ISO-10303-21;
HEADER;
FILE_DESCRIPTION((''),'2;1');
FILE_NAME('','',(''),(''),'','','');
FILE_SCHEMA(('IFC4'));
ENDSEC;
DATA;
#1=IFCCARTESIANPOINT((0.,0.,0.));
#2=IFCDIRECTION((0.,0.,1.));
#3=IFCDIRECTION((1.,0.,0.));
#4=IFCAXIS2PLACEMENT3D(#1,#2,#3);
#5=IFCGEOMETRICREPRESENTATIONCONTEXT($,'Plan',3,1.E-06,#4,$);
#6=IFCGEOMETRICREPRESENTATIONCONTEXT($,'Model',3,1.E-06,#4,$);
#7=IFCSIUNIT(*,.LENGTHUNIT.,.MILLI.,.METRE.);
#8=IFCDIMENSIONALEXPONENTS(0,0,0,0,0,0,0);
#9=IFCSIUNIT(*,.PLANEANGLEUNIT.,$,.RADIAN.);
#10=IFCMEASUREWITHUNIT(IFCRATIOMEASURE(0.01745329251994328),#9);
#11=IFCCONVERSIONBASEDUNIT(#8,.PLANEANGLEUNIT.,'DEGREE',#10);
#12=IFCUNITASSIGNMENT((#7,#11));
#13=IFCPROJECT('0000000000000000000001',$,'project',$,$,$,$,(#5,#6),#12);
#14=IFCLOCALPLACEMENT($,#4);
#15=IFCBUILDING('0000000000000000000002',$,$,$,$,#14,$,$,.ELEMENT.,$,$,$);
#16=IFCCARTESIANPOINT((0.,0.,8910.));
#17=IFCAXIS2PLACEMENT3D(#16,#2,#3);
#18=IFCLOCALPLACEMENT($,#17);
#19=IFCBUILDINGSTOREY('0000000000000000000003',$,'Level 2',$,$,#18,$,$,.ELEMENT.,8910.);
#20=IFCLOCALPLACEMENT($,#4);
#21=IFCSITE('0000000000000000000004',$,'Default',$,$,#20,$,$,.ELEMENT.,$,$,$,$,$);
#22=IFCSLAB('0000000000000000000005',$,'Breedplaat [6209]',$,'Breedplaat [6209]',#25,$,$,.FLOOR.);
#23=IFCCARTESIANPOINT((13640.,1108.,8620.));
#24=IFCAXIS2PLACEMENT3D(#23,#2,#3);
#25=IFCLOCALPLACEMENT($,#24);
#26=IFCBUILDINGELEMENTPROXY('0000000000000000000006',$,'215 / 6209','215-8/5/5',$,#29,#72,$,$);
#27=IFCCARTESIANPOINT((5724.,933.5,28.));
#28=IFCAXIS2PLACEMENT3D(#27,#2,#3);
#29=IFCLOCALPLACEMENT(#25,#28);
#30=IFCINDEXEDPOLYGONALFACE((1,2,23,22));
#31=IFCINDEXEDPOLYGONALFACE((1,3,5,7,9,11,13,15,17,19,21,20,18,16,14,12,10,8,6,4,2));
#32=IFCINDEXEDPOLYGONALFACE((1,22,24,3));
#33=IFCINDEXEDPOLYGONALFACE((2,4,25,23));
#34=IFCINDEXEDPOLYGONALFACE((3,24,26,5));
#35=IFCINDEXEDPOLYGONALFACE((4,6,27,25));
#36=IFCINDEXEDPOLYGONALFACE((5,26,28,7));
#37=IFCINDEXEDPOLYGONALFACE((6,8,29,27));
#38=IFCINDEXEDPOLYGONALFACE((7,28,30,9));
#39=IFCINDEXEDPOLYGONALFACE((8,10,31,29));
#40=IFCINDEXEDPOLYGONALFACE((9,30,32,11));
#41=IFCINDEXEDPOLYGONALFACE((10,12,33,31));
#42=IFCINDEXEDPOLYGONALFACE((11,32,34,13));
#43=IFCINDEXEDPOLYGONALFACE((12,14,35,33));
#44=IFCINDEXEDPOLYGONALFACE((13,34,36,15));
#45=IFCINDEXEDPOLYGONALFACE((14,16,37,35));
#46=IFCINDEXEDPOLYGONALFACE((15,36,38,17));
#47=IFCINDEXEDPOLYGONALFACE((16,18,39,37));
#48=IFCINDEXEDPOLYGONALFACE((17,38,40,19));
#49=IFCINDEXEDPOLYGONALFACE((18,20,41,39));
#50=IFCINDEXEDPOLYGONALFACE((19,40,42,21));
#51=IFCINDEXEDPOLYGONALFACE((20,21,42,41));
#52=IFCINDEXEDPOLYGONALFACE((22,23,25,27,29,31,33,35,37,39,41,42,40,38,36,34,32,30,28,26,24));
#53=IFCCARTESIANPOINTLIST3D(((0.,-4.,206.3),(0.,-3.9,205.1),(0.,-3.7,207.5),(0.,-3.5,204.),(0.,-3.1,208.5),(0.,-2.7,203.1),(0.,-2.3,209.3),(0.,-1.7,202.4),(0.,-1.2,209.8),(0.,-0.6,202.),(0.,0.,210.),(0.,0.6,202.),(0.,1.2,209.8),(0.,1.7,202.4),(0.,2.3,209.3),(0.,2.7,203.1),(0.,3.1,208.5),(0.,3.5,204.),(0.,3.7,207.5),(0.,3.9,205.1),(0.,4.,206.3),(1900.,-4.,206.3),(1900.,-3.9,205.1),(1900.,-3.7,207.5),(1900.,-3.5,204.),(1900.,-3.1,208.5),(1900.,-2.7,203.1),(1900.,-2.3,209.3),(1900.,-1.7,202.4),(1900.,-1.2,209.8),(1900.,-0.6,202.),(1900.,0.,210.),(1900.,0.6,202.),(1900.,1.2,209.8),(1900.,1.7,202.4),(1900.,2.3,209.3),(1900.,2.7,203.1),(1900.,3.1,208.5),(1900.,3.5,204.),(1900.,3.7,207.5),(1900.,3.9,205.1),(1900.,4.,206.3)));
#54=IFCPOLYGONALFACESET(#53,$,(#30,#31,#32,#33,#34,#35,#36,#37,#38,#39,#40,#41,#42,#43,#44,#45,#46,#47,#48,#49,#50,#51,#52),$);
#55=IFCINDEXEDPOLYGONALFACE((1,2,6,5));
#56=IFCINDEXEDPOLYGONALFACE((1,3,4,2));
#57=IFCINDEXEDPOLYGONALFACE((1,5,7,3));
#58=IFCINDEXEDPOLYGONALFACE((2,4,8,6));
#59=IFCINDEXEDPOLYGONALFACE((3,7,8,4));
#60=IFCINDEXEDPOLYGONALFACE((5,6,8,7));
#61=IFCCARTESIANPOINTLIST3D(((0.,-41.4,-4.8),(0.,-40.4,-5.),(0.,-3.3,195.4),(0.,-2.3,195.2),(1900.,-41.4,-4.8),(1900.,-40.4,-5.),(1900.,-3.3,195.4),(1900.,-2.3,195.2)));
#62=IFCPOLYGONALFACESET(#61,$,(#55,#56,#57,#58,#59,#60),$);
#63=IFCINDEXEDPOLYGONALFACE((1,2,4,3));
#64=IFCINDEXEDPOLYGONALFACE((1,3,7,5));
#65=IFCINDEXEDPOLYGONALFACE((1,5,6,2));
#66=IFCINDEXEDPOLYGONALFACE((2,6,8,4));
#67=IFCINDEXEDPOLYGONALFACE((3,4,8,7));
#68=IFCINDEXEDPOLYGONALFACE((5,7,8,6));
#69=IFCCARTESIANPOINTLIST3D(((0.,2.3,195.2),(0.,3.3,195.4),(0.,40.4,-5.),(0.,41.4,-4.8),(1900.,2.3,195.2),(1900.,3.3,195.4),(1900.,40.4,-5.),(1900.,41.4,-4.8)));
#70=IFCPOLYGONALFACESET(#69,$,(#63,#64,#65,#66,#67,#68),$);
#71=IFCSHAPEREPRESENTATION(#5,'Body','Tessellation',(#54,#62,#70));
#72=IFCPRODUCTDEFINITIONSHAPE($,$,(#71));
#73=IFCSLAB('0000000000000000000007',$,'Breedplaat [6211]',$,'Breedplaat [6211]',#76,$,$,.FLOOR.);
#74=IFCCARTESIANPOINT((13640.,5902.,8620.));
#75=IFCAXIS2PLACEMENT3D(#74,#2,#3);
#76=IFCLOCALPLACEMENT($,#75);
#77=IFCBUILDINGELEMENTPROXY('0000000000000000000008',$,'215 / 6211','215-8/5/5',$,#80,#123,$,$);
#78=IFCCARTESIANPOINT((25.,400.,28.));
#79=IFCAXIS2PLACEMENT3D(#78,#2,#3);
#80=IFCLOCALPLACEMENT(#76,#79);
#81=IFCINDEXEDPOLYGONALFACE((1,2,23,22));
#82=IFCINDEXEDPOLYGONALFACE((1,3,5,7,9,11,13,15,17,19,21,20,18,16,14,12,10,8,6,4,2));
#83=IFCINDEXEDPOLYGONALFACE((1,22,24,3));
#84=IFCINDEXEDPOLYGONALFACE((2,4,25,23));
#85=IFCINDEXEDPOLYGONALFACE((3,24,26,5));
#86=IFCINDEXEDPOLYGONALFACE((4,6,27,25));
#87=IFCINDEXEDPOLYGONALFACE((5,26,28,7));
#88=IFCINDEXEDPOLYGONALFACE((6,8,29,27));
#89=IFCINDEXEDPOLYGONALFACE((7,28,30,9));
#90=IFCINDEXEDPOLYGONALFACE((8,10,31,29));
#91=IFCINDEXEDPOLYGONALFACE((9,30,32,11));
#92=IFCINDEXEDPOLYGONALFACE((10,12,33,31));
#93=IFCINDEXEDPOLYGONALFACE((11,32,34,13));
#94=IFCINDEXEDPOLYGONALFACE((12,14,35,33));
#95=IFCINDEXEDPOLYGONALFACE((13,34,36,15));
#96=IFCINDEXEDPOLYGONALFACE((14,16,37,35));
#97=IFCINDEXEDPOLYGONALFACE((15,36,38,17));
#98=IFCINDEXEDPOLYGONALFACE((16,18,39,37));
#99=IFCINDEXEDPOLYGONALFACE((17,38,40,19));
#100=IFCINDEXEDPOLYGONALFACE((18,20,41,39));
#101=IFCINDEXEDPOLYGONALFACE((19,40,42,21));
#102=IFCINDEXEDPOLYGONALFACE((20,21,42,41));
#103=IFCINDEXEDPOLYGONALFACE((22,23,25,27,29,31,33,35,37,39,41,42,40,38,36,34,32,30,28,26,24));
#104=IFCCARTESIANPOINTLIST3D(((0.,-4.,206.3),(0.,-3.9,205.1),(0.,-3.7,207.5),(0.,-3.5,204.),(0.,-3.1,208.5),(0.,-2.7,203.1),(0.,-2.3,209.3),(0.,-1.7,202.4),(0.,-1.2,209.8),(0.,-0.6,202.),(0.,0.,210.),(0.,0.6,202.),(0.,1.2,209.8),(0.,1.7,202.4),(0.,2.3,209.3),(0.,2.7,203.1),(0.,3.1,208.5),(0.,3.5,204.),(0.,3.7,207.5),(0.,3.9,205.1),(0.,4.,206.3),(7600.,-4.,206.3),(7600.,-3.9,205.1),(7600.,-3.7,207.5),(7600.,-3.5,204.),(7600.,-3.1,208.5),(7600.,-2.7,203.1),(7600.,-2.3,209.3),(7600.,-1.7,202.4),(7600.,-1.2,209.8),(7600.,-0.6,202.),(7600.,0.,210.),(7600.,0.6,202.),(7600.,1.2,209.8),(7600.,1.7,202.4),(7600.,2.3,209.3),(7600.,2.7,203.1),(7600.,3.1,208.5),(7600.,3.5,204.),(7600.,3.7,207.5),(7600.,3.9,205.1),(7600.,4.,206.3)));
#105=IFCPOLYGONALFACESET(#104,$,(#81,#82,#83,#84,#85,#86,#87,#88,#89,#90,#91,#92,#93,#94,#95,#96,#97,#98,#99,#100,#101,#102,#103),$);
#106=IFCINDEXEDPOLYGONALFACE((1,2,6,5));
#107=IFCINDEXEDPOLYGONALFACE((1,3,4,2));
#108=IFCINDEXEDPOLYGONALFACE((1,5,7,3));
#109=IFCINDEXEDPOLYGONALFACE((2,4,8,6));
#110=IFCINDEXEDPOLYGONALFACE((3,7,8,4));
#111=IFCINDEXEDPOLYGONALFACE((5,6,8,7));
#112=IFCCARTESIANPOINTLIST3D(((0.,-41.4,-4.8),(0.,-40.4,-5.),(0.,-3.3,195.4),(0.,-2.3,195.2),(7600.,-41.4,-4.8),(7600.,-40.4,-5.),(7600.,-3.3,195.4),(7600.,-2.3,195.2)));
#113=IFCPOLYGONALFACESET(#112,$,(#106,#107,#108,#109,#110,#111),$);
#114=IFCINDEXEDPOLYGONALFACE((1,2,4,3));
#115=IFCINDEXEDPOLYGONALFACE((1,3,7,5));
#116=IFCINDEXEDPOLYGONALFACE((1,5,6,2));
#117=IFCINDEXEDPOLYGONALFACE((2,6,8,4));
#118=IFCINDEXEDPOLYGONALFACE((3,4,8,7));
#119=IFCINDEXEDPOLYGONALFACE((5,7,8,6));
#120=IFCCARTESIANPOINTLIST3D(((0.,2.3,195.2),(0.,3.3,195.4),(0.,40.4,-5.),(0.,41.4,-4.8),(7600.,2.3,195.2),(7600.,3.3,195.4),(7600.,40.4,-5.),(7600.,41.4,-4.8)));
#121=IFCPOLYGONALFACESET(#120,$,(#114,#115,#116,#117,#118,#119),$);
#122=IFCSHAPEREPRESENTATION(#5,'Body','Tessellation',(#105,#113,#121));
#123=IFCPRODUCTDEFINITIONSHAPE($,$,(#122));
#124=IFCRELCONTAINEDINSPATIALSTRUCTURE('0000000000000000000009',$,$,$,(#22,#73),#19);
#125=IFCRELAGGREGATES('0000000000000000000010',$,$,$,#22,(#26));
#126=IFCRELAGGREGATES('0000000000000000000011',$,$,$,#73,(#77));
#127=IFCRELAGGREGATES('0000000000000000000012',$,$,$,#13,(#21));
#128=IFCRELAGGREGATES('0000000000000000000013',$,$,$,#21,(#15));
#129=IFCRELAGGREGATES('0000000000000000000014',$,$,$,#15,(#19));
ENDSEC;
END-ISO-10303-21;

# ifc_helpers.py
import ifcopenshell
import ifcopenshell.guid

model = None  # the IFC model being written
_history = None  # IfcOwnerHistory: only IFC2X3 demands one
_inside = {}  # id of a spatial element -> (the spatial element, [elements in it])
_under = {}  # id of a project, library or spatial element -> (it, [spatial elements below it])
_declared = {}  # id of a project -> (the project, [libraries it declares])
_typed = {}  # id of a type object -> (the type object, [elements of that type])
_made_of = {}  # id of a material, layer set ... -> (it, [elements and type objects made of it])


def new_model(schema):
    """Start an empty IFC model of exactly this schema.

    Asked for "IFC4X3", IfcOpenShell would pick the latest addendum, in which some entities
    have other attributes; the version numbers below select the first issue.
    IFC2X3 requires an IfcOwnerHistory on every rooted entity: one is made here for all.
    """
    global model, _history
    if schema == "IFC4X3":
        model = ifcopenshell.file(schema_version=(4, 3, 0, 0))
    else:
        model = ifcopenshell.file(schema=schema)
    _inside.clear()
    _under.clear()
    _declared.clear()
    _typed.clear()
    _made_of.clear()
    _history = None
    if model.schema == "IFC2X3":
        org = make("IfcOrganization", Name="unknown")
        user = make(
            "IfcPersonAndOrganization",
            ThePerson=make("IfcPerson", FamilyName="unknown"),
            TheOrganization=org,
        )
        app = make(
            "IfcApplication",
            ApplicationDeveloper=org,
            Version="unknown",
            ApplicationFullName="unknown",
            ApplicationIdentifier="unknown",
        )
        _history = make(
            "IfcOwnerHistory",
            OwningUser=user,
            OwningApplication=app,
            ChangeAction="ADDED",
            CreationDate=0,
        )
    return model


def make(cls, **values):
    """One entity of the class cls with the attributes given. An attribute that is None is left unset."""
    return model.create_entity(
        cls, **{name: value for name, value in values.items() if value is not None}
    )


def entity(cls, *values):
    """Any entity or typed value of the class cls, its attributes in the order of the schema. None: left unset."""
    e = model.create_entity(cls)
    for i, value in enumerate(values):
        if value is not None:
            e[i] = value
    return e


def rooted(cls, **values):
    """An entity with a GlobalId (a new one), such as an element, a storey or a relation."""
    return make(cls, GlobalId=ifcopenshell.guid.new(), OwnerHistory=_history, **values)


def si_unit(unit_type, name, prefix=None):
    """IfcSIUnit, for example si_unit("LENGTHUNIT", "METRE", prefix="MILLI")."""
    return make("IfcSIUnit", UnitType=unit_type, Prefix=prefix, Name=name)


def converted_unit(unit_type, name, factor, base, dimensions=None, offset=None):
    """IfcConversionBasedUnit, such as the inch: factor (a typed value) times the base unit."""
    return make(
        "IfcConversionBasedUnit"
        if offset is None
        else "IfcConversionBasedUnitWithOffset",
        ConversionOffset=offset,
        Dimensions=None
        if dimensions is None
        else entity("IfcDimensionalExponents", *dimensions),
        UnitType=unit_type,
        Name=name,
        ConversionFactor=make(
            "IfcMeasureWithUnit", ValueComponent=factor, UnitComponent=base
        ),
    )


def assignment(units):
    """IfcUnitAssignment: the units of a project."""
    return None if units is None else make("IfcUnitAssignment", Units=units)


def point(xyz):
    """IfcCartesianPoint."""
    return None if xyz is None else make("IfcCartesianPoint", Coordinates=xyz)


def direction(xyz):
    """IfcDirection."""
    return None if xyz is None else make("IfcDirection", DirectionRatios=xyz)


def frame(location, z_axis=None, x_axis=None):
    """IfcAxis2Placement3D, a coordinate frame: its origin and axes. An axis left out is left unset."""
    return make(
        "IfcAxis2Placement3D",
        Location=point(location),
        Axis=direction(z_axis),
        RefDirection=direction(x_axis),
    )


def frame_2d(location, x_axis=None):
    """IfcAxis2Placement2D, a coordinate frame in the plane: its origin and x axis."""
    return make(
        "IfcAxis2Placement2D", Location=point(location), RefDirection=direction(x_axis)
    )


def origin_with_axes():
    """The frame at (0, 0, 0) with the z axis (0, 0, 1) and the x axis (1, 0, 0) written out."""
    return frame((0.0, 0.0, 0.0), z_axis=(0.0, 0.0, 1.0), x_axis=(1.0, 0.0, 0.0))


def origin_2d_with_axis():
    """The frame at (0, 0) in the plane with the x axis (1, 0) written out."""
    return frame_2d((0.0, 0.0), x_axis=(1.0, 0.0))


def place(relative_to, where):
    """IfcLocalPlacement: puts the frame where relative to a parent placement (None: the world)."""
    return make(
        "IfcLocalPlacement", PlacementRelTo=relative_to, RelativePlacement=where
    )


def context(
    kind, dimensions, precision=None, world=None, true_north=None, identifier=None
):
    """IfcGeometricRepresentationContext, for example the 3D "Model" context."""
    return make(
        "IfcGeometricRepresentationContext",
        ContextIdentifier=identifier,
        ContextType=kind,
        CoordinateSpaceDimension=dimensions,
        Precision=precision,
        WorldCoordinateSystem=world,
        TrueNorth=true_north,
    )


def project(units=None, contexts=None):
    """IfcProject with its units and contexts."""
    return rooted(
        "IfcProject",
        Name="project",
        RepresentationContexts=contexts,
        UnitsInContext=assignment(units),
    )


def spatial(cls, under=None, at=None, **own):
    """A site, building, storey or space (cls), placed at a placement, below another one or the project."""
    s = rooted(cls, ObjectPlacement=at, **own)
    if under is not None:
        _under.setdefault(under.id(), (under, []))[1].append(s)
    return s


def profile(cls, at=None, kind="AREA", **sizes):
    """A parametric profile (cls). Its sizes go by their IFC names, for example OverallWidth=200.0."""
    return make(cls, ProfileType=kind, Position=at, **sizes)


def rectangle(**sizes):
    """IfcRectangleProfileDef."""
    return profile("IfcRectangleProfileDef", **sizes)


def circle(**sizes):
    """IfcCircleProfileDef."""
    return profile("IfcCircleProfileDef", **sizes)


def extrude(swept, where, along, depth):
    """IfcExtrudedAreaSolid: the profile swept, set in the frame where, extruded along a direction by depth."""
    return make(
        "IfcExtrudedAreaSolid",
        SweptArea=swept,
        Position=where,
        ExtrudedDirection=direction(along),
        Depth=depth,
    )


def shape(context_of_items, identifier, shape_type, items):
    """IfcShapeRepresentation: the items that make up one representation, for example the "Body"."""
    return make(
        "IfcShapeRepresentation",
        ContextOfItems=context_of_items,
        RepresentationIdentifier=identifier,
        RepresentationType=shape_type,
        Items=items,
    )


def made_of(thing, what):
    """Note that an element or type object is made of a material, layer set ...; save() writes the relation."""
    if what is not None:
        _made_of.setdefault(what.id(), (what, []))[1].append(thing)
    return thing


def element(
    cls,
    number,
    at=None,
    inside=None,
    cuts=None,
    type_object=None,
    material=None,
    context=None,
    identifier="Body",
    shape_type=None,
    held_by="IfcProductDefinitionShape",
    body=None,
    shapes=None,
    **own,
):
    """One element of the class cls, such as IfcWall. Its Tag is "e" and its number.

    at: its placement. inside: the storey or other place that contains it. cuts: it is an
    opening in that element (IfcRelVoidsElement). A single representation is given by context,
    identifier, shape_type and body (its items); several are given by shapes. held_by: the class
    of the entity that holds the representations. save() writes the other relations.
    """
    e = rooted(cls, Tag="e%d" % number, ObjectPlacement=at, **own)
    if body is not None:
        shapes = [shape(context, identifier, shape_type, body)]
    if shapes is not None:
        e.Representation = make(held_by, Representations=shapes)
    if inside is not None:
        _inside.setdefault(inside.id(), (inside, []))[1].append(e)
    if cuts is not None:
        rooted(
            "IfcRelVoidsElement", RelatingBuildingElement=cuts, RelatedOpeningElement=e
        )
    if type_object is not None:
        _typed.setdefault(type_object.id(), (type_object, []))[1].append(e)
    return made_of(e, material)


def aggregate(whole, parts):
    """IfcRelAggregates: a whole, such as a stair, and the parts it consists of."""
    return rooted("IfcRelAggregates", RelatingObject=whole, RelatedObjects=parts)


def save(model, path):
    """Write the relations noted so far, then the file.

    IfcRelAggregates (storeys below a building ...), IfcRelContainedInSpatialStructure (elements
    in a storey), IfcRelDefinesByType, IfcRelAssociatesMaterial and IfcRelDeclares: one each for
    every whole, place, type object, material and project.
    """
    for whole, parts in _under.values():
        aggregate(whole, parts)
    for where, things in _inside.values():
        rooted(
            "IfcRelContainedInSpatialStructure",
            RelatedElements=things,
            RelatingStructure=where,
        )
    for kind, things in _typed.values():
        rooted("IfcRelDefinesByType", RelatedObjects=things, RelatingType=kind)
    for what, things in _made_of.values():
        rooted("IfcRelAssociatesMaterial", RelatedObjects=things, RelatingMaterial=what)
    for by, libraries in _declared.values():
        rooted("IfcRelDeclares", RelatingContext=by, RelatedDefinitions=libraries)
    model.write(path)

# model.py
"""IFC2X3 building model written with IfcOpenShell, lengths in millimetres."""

from ifc_helpers import new_model, entity, si_unit, converted_unit, frame, origin_with_axes, origin_2d_with_axis, place, context, project, spatial, rectangle, circle, extrude, element, aggregate, save


model = new_model("IFC2X3")

# Units and contexts
plan_context = context("Plan", 3, precision=1e-06, world=origin_with_axes())
model_context = context("Model", 3, precision=1e-06, world=origin_with_axes())
ifc_project = project(units=[si_unit("LENGTHUNIT", "METRE", prefix="MILLI"), converted_unit("PLANEANGLEUNIT", "DEGREE", entity("IfcRatioMeasure", 0.01745329251994328), si_unit("PLANEANGLEUNIT", "RADIAN"), dimensions=[0, 0, 0, 0, 0, 0, 0])], contexts=[plan_context, model_context])

# Site, building, storey
site_placement = place(None, origin_with_axes())
site = spatial("IfcSite", under=ifc_project, at=site_placement, Name="Default", CompositionType="ELEMENT")
building_placement = place(None, origin_with_axes())
building = spatial("IfcBuilding", under=site, at=building_placement, CompositionType="ELEMENT")
storey_placement = place(None, frame((0.0, 0.0, 8910.0), z_axis=(0.0, 0.0, 1.0), x_axis=(1.0, 0.0, 0.0)))
storey = spatial("IfcBuildingStorey", under=building, at=storey_placement, Name="Level 2", CompositionType="ELEMENT", Elevation=8910.0)

# Slabs, building element proxies
slab_1_placement = place(None, frame((13640.0, 1108.0, 8620.0), z_axis=(0.0, 0.0, 1.0), x_axis=(1.0, 0.0, 0.0)))
slab_1 = element("IfcSlab", 1, at=slab_1_placement, inside=storey, Name="Breedplaat [6209]", ObjectType="Breedplaat [6209]", PredefinedType="FLOOR")
proxy_1_placement = place(slab_1_placement, frame((5724.0, 933.5, 28.0), z_axis=(0.0, 0.0, 1.0), x_axis=(1.0, 0.0, 0.0)))
proxy_1 = element("IfcBuildingElementProxy", 2, at=proxy_1_placement, Name="215 / 6209", Description="215-8/5/5", context=plan_context, shape_type="SweptSolid", body=[
    extrude(circle(Radius=4.0, at=origin_2d_with_axis()), frame((0.0, 0.0, 206.0), z_axis=(1.0, 0.0, 0.0), x_axis=(0.0, 0.0, 1.0)), (0.0, 0.0, 1.0), 1900.0),
    extrude(rectangle(XDim=203.8, YDim=1.0, at=origin_2d_with_axis()), frame((0.0, -21.9, 95.2), z_axis=(1.0, 0.0, 0.0), x_axis=(0.0, 0.187112, 0.982339)), (0.0, 0.0, 1.0), 1900.0),
    extrude(rectangle(XDim=203.8, YDim=1.0, at=origin_2d_with_axis()), frame((0.0, 21.9, 95.2), z_axis=(1.0, 0.0, 0.0), x_axis=(0.0, -0.187112, 0.982339)), (0.0, 0.0, 1.0), 1900.0),
])
aggregate(slab_1, [proxy_1])
slab_2_placement = place(None, frame((13640.0, 5902.0, 8620.0), z_axis=(0.0, 0.0, 1.0), x_axis=(1.0, 0.0, 0.0)))
slab_2 = element("IfcSlab", 3, at=slab_2_placement, inside=storey, Name="Breedplaat [6211]", ObjectType="Breedplaat [6211]", PredefinedType="FLOOR")
proxy_2_placement = place(slab_2_placement, frame((25.0, 400.0, 28.0), z_axis=(0.0, 0.0, 1.0), x_axis=(1.0, 0.0, 0.0)))
proxy_2 = element("IfcBuildingElementProxy", 4, at=proxy_2_placement, Name="215 / 6211", Description="215-8/5/5", context=plan_context, shape_type="SweptSolid", body=[
    extrude(circle(Radius=4.0, at=origin_2d_with_axis()), frame((0.0, 0.0, 206.0), z_axis=(1.0, 0.0, 0.0), x_axis=(0.0, 0.0, 1.0)), (0.0, 0.0, 1.0), 7600.0),
    extrude(rectangle(XDim=203.8, YDim=1.0, at=origin_2d_with_axis()), frame((0.0, -21.9, 95.2), z_axis=(1.0, 0.0, 0.0), x_axis=(0.0, 0.187112, 0.982339)), (0.0, 0.0, 1.0), 7600.0),
    extrude(rectangle(XDim=203.8, YDim=1.0, at=origin_2d_with_axis()), frame((0.0, 21.9, 95.2), z_axis=(1.0, 0.0, 0.0), x_axis=(0.0, -0.187112, 0.982339)), (0.0, 0.0, 1.0), 7600.0),
])
aggregate(slab_2, [proxy_2])

save(model, "model.ifc")
